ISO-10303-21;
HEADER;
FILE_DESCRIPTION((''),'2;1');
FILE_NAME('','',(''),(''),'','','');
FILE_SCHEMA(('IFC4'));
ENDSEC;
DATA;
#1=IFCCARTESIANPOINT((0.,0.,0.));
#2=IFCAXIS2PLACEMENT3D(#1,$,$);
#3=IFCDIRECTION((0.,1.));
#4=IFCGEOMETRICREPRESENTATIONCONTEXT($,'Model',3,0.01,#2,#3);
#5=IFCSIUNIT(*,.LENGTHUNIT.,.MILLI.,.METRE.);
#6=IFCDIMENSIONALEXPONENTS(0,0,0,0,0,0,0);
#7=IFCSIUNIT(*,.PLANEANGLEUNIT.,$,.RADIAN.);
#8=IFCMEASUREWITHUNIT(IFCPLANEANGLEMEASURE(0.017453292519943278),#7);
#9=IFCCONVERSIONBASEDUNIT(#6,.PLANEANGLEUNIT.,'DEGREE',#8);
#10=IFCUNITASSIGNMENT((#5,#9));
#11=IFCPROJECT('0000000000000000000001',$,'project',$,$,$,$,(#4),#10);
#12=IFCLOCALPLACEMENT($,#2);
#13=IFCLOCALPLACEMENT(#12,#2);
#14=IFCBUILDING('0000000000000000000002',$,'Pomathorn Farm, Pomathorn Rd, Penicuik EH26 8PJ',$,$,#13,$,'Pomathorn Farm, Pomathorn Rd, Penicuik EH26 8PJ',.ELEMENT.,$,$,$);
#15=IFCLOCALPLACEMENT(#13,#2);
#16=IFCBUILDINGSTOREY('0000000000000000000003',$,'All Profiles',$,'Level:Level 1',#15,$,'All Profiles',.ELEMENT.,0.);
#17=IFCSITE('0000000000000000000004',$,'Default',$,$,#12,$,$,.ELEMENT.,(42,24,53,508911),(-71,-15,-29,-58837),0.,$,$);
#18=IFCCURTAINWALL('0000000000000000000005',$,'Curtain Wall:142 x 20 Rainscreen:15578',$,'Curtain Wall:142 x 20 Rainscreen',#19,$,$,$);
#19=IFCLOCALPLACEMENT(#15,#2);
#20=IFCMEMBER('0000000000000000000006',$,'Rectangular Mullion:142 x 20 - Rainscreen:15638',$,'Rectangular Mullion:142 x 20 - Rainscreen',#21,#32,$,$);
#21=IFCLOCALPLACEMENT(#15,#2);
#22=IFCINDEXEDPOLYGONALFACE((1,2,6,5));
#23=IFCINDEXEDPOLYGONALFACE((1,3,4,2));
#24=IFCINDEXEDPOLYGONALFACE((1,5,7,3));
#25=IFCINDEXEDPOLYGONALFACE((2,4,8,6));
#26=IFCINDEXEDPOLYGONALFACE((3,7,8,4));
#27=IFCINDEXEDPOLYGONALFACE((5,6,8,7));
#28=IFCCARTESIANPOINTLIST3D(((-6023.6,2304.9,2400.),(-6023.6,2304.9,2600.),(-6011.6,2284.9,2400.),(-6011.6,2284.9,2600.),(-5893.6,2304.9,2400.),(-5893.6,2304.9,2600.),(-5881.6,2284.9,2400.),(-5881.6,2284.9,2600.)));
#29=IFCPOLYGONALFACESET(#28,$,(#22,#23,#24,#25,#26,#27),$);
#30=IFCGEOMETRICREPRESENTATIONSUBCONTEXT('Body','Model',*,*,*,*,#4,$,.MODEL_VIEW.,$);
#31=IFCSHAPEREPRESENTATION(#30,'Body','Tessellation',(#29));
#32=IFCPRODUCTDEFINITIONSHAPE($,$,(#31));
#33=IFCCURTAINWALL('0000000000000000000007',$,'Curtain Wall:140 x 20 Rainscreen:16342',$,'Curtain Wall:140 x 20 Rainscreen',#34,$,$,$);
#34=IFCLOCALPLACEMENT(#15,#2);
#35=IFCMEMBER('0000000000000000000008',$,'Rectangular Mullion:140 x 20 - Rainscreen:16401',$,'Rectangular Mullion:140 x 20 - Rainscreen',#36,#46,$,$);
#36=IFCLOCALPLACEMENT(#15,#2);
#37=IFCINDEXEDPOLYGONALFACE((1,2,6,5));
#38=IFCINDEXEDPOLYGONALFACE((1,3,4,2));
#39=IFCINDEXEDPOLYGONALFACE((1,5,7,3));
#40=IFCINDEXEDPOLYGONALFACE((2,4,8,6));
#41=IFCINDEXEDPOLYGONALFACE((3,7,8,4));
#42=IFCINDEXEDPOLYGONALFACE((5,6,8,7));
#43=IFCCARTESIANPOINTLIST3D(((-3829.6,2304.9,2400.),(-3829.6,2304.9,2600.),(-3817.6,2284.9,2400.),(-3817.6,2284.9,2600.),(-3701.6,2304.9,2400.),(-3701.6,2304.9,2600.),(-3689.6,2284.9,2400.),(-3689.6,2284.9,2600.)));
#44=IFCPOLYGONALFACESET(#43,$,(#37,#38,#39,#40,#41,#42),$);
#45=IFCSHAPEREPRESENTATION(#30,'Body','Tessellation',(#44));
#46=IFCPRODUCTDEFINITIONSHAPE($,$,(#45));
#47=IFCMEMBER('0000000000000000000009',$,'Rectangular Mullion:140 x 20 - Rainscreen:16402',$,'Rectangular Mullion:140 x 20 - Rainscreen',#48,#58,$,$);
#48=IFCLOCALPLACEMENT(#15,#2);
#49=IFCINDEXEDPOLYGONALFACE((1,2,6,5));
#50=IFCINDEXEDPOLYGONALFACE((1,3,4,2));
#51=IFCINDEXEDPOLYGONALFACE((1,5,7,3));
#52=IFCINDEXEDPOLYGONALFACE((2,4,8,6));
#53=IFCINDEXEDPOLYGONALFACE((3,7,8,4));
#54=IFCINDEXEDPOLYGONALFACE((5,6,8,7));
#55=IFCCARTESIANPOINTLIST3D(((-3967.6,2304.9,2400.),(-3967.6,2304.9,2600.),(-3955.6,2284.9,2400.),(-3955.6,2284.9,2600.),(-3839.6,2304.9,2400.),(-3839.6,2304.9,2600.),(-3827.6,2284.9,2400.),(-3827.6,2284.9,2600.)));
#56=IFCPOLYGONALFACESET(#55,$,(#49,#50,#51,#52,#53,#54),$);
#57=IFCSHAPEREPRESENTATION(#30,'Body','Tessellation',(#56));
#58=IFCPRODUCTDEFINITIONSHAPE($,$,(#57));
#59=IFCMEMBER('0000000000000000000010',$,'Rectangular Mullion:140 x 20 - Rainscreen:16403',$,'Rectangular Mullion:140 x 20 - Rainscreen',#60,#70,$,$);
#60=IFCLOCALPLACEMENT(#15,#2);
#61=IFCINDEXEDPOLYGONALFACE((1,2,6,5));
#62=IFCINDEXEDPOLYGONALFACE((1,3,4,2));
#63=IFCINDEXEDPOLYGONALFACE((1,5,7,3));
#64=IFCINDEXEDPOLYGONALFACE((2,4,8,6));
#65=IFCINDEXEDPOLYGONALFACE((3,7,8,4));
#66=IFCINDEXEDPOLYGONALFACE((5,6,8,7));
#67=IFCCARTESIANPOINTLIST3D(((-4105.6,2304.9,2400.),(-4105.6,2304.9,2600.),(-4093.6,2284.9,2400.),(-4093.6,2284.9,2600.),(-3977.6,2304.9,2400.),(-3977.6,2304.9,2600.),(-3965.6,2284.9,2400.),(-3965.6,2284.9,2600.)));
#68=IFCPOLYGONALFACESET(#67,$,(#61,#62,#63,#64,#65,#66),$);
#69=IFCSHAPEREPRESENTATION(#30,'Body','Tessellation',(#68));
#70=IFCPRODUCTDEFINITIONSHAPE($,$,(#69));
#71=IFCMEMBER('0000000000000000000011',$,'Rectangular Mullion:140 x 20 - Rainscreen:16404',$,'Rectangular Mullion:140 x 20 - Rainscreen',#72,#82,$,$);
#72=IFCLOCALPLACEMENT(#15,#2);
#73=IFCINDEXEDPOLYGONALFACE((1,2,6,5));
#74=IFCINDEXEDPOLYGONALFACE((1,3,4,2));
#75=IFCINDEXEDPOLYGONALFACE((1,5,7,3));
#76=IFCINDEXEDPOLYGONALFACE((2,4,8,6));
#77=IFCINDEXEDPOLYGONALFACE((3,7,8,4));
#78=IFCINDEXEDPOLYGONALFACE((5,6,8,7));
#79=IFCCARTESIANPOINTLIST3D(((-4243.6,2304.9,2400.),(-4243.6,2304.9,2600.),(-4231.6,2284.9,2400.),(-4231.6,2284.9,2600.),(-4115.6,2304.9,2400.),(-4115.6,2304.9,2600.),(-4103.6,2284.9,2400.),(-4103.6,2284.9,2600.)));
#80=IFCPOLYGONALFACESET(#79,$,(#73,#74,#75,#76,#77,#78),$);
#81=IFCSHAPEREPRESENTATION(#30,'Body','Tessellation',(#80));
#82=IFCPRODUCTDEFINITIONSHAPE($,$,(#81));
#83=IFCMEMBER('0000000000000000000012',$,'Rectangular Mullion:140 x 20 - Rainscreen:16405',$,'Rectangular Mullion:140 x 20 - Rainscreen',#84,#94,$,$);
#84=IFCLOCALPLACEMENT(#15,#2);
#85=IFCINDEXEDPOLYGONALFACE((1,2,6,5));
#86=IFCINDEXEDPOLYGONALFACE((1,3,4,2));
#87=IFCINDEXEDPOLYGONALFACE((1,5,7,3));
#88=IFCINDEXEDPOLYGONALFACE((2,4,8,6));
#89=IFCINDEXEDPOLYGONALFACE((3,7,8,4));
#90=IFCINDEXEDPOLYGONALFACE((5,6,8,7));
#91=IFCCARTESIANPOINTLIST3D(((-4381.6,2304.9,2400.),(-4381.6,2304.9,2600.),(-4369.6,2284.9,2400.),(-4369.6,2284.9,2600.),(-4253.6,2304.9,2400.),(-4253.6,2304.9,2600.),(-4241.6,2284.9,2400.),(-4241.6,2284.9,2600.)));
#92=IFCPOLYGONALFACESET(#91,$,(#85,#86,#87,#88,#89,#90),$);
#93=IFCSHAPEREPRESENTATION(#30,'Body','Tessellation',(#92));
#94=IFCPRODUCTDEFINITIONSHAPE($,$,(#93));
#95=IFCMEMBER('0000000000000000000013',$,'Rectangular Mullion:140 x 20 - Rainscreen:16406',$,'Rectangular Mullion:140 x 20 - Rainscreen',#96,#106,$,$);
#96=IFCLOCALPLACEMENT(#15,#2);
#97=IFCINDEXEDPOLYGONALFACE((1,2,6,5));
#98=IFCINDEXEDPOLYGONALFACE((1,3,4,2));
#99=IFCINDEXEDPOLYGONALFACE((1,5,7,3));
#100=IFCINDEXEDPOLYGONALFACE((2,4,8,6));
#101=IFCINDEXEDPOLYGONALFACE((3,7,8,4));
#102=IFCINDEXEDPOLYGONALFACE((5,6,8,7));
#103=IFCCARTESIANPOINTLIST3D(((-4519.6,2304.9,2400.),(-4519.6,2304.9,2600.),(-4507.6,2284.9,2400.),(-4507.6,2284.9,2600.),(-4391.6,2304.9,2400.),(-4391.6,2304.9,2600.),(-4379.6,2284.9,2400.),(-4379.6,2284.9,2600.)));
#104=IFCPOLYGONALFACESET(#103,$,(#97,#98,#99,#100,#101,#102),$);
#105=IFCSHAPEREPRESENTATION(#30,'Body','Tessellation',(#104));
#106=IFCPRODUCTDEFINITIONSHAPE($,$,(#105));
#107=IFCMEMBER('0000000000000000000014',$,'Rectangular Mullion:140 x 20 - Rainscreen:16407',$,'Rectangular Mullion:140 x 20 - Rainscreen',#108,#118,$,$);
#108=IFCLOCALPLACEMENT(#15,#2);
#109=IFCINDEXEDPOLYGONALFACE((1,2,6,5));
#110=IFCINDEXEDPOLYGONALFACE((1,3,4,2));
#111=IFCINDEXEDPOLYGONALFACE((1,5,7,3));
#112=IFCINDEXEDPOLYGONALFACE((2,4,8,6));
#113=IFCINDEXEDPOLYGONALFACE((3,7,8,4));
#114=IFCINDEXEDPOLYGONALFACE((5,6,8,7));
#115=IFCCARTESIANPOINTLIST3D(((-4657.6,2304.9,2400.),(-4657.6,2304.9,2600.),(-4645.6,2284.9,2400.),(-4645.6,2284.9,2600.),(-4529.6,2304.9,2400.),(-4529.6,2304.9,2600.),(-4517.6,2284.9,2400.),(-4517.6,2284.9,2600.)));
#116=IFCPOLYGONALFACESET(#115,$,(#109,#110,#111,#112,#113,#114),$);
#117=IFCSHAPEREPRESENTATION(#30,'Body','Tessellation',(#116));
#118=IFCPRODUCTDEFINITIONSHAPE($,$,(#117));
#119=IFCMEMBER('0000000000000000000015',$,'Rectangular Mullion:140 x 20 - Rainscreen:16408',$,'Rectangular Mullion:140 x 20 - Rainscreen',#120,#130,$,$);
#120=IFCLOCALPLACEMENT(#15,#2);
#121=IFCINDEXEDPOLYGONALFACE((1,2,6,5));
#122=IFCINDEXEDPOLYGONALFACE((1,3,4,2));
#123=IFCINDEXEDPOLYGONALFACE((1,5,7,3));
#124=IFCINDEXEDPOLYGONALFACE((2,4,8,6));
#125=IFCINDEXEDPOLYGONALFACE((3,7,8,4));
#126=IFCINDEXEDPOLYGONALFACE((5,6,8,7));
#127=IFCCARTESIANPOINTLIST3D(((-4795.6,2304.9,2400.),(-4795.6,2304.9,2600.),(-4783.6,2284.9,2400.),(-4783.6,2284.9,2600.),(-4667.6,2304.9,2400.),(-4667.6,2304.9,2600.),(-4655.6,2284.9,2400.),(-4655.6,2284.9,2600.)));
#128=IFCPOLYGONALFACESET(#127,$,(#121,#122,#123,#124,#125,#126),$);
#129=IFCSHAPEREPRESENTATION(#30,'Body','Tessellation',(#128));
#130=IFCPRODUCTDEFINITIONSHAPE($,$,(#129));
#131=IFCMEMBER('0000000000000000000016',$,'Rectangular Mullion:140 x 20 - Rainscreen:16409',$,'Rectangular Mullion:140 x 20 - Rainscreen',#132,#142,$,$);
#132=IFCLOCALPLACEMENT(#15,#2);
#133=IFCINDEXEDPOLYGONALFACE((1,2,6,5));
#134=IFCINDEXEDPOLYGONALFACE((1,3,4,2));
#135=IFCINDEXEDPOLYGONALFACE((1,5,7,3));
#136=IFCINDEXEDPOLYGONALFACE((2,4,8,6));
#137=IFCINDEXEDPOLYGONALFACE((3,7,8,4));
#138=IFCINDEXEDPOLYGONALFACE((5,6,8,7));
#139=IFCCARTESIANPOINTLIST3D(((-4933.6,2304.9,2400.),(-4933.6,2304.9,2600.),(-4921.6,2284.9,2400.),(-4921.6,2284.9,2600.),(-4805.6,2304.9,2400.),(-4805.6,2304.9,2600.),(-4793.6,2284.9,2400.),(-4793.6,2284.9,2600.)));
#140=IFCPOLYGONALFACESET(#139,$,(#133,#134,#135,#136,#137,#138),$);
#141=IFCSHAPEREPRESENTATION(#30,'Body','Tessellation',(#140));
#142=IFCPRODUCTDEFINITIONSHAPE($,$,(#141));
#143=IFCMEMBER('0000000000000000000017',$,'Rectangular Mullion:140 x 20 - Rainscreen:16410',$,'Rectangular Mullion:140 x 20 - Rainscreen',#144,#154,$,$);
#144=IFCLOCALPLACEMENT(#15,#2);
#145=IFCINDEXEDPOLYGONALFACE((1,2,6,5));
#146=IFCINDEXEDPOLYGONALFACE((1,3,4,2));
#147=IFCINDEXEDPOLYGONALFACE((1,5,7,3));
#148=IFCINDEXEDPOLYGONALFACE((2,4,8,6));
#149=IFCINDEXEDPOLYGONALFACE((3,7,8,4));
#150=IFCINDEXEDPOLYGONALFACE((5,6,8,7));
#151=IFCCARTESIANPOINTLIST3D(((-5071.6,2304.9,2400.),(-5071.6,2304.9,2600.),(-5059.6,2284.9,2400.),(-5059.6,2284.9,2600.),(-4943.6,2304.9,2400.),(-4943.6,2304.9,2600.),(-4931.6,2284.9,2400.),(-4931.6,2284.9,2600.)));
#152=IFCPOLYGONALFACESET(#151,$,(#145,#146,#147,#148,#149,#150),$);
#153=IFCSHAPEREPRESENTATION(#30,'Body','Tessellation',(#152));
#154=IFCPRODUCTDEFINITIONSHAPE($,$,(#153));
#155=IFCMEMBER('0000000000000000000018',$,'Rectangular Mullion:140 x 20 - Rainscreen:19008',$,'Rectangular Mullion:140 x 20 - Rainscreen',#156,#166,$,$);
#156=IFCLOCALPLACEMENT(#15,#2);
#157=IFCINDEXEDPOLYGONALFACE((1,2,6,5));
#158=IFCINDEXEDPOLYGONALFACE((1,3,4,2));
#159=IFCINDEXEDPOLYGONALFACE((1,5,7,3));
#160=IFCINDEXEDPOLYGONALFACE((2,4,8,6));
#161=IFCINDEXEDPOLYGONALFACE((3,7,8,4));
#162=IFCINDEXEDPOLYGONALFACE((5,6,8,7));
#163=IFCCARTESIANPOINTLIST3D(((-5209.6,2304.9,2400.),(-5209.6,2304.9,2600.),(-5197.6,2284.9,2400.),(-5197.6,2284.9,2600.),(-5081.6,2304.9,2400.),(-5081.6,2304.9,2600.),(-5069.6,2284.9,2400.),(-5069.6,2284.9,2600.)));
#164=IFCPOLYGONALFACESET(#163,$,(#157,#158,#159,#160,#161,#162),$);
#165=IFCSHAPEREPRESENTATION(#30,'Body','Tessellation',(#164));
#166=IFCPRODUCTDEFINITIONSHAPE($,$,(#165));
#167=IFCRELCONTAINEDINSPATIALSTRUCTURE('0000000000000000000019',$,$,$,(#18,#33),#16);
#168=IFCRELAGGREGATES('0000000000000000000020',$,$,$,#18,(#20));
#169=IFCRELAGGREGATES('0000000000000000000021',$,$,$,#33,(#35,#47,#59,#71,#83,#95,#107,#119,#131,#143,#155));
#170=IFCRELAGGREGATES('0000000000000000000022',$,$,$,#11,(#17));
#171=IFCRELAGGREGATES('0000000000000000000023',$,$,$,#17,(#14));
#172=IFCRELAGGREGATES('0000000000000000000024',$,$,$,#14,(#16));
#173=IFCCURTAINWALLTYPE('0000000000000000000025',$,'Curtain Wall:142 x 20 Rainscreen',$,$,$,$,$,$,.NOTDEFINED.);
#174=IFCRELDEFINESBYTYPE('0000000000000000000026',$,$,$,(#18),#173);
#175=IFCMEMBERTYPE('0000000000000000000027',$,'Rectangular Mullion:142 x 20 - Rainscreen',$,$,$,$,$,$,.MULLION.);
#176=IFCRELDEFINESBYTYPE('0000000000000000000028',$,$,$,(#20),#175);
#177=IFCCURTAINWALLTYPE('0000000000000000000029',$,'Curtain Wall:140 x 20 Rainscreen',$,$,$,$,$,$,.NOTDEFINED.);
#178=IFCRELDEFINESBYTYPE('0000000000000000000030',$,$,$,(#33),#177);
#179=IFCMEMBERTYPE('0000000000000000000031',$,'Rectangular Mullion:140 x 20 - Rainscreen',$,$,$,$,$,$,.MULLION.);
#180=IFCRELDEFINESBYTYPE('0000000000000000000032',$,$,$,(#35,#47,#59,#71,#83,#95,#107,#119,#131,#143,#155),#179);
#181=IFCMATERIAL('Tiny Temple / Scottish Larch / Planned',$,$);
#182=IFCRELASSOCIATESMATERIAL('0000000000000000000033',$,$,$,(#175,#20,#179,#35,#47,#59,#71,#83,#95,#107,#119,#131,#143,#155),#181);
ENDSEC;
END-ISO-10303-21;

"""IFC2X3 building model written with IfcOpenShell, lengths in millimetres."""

from ifc_helpers import new_model, entity, si_unit, converted_unit, direction, frame, origin, place, context, subcontext, project, spatial, polyline, outline, extrude, source, transform, mapped, material, type_object, type_shapes, element, aggregate, save


model = new_model("IFC2X3")

# Units and contexts
model_context = context("Model", 3, precision=0.01, world=origin(), true_north=direction((0.0, 1.0)))
body_context = subcontext(model_context, "Body", "Model", "MODEL_VIEW")
ifc_project = project(units=[si_unit("LENGTHUNIT", "METRE", prefix="MILLI"), converted_unit("PLANEANGLEUNIT", "DEGREE", entity("IfcPlaneAngleMeasure", 0.017453292519943278), si_unit("PLANEANGLEUNIT", "RADIAN"), dimensions=[0, 0, 0, 0, 0, 0, 0])], contexts=[model_context])

# Site, building, storey
site_placement = place(None, origin())
site = spatial("IfcSite", under=ifc_project, at=site_placement, Name="Default", CompositionType="ELEMENT", RefLatitude=(42, 24, 53, 508911), RefLongitude=(-71, -15, -29, -58837), RefElevation=0.0)
building_placement = place(site_placement, origin())
building = spatial("IfcBuilding", under=site, at=building_placement, Name="Pomathorn Farm, Pomathorn Rd, Penicuik EH26 8PJ", LongName="Pomathorn Farm, Pomathorn Rd, Penicuik EH26 8PJ", CompositionType="ELEMENT")
storey_placement = place(building_placement, origin())
storey = spatial("IfcBuildingStorey", under=building, at=storey_placement, Name="All Profiles", ObjectType="Level:Level 1", LongName="All Profiles", CompositionType="ELEMENT", Elevation=0.0)

# Curtain walls, members
ifc_material = material(Name="Tiny Temple / Scottish Larch / Planned")
curtain_wall_type_1 = type_object("IfcCurtainWallType", Name="Curtain Wall:142 x 20 Rainscreen", PredefinedType="NOTDEFINED")
curtain_wall_1_placement = place(storey_placement, origin())
curtain_wall_1 = element("IfcCurtainWall", 1, at=curtain_wall_1_placement, inside=storey, type_object=curtain_wall_type_1, Name="Curtain Wall:142 x 20 Rainscreen:15578", ObjectType="Curtain Wall:142 x 20 Rainscreen")
member_type_1 = type_object("IfcMemberType", Name="Rectangular Mullion:142 x 20 - Rainscreen", PredefinedType="MULLION", material=ifc_material)
shared_shape_1 = source(origin(), body_context, "Body", "SweptSolid", [
    extrude(outline(polyline([(21.8, -55.7), (45.1, -55.7), (-21.8, 55.7), (-45.1, 55.7), (21.8, -55.7)])), frame((-71.0, -10.0, -200.0), z_axis=(0.0, 0.0, 1.0), x_axis=(0.514496, 0.857493, 0.0)), (0.0, 0.0, 1.0), 200.0),
])
type_shapes(member_type_1, [shared_shape_1])
member_1_placement = place(curtain_wall_1_placement, frame((-5881.6, 2284.9, 2400.0), z_axis=(0.0, 0.0, -1.0), x_axis=(1.0, 0.0, 0.0)))
member_1 = element("IfcMember", 2, at=member_1_placement, type_object=member_type_1, material=ifc_material, Name="Rectangular Mullion:142 x 20 - Rainscreen:15638", ObjectType="Rectangular Mullion:142 x 20 - Rainscreen", context=body_context, shape_type="MappedRepresentation", body=[
    mapped(shared_shape_1, transform((0.0, 0.0, 0.0), scale=1.0)),
])
aggregate(curtain_wall_1, [member_1])
curtain_wall_type_2 = type_object("IfcCurtainWallType", Name="Curtain Wall:140 x 20 Rainscreen", PredefinedType="NOTDEFINED")
curtain_wall_2_placement = place(storey_placement, origin())
curtain_wall_2 = element("IfcCurtainWall", 3, at=curtain_wall_2_placement, inside=storey, type_object=curtain_wall_type_2, Name="Curtain Wall:140 x 20 Rainscreen:16342", ObjectType="Curtain Wall:140 x 20 Rainscreen")
member_type_2 = type_object("IfcMemberType", Name="Rectangular Mullion:140 x 20 - Rainscreen", PredefinedType="MULLION", material=ifc_material)
shared_shape_2 = source(origin(), body_context, "Body", "SweptSolid", [
    extrude(outline(polyline([(21.3, -54.9), (44.6, -54.9), (-21.3, 54.9), (-44.6, 54.9), (21.3, -54.9)])), frame((-70.0, -10.0, -200.0), z_axis=(0.0, 0.0, 1.0), x_axis=(0.514496, 0.857493, 0.0)), (0.0, 0.0, 1.0), 200.0),
])
type_shapes(member_type_2, [shared_shape_2])
member_2_placement = place(curtain_wall_2_placement, frame((-3689.6, 2284.9, 2400.0), z_axis=(0.0, 0.0, -1.0), x_axis=(1.0, 0.0, 0.0)))
member_2 = element("IfcMember", 4, at=member_2_placement, type_object=member_type_2, material=ifc_material, Name="Rectangular Mullion:140 x 20 - Rainscreen:16401", ObjectType="Rectangular Mullion:140 x 20 - Rainscreen", context=body_context, shape_type="MappedRepresentation", body=[
    mapped(shared_shape_2, transform((0.0, 0.0, 0.0), scale=1.0)),
])
member_3_placement = place(curtain_wall_2_placement, frame((-3827.6, 2284.9, 2400.0), z_axis=(0.0, 0.0, -1.0), x_axis=(1.0, 0.0, 0.0)))
member_3 = element("IfcMember", 5, at=member_3_placement, type_object=member_type_2, material=ifc_material, Name="Rectangular Mullion:140 x 20 - Rainscreen:16402", ObjectType="Rectangular Mullion:140 x 20 - Rainscreen", context=body_context, shape_type="MappedRepresentation", body=[
    mapped(shared_shape_2, transform((0.0, 0.0, 0.0), scale=1.0)),
])
member_4_placement = place(curtain_wall_2_placement, frame((-3965.6, 2284.9, 2400.0), z_axis=(0.0, 0.0, -1.0), x_axis=(1.0, 0.0, 0.0)))
member_4 = element("IfcMember", 6, at=member_4_placement, type_object=member_type_2, material=ifc_material, Name="Rectangular Mullion:140 x 20 - Rainscreen:16403", ObjectType="Rectangular Mullion:140 x 20 - Rainscreen", context=body_context, shape_type="MappedRepresentation", body=[
    mapped(shared_shape_2, transform((0.0, 0.0, 0.0), scale=1.0)),
])
member_5_placement = place(curtain_wall_2_placement, frame((-4103.6, 2284.9, 2400.0), z_axis=(0.0, 0.0, -1.0), x_axis=(1.0, 0.0, 0.0)))
member_5 = element("IfcMember", 7, at=member_5_placement, type_object=member_type_2, material=ifc_material, Name="Rectangular Mullion:140 x 20 - Rainscreen:16404", ObjectType="Rectangular Mullion:140 x 20 - Rainscreen", context=body_context, shape_type="MappedRepresentation", body=[
    mapped(shared_shape_2, transform((0.0, 0.0, 0.0), scale=1.0)),
])
member_6_placement = place(curtain_wall_2_placement, frame((-4241.6, 2284.9, 2400.0), z_axis=(0.0, 0.0, -1.0), x_axis=(1.0, 0.0, 0.0)))
member_6 = element("IfcMember", 8, at=member_6_placement, type_object=member_type_2, material=ifc_material, Name="Rectangular Mullion:140 x 20 - Rainscreen:16405", ObjectType="Rectangular Mullion:140 x 20 - Rainscreen", context=body_context, shape_type="MappedRepresentation", body=[
    mapped(shared_shape_2, transform((0.0, 0.0, 0.0), scale=1.0)),
])
member_7_placement = place(curtain_wall_2_placement, frame((-4379.6, 2284.9, 2400.0), z_axis=(0.0, 0.0, -1.0), x_axis=(1.0, 0.0, 0.0)))
member_7 = element("IfcMember", 9, at=member_7_placement, type_object=member_type_2, material=ifc_material, Name="Rectangular Mullion:140 x 20 - Rainscreen:16406", ObjectType="Rectangular Mullion:140 x 20 - Rainscreen", context=body_context, shape_type="MappedRepresentation", body=[
    mapped(shared_shape_2, transform((0.0, 0.0, 0.0), scale=1.0)),
])
member_8_placement = place(curtain_wall_2_placement, frame((-4517.6, 2284.9, 2400.0), z_axis=(0.0, 0.0, -1.0), x_axis=(1.0, 0.0, 0.0)))
member_8 = element("IfcMember", 10, at=member_8_placement, type_object=member_type_2, material=ifc_material, Name="Rectangular Mullion:140 x 20 - Rainscreen:16407", ObjectType="Rectangular Mullion:140 x 20 - Rainscreen", context=body_context, shape_type="MappedRepresentation", body=[
    mapped(shared_shape_2, transform((0.0, 0.0, 0.0), scale=1.0)),
])
member_9_placement = place(curtain_wall_2_placement, frame((-4655.6, 2284.9, 2400.0), z_axis=(0.0, 0.0, -1.0), x_axis=(1.0, 0.0, 0.0)))
member_9 = element("IfcMember", 11, at=member_9_placement, type_object=member_type_2, material=ifc_material, Name="Rectangular Mullion:140 x 20 - Rainscreen:16408", ObjectType="Rectangular Mullion:140 x 20 - Rainscreen", context=body_context, shape_type="MappedRepresentation", body=[
    mapped(shared_shape_2, transform((0.0, 0.0, 0.0), scale=1.0)),
])
member_10_placement = place(curtain_wall_2_placement, frame((-4793.6, 2284.9, 2400.0), z_axis=(0.0, 0.0, -1.0), x_axis=(1.0, 0.0, 0.0)))
member_10 = element("IfcMember", 12, at=member_10_placement, type_object=member_type_2, material=ifc_material, Name="Rectangular Mullion:140 x 20 - Rainscreen:16409", ObjectType="Rectangular Mullion:140 x 20 - Rainscreen", context=body_context, shape_type="MappedRepresentation", body=[
    mapped(shared_shape_2, transform((0.0, 0.0, 0.0), scale=1.0)),
])
member_11_placement = place(curtain_wall_2_placement, frame((-4931.6, 2284.9, 2400.0), z_axis=(0.0, 0.0, -1.0), x_axis=(1.0, 0.0, 0.0)))
member_11 = element("IfcMember", 13, at=member_11_placement, type_object=member_type_2, material=ifc_material, Name="Rectangular Mullion:140 x 20 - Rainscreen:16410", ObjectType="Rectangular Mullion:140 x 20 - Rainscreen", context=body_context, shape_type="MappedRepresentation", body=[
    mapped(shared_shape_2, transform((0.0, 0.0, 0.0), scale=1.0)),
])
member_12_placement = place(curtain_wall_2_placement, frame((-5069.6, 2284.9, 2400.0), z_axis=(0.0, 0.0, -1.0), x_axis=(1.0, 0.0, 0.0)))
member_12 = element("IfcMember", 14, at=member_12_placement, type_object=member_type_2, material=ifc_material, Name="Rectangular Mullion:140 x 20 - Rainscreen:19008", ObjectType="Rectangular Mullion:140 x 20 - Rainscreen", context=body_context, shape_type="MappedRepresentation", body=[
    mapped(shared_shape_2, transform((0.0, 0.0, 0.0), scale=1.0)),
])
aggregate(curtain_wall_2, [member_2, member_3, member_4, member_5, member_6, member_7, member_8, member_9, member_10, member_11, member_12])

save(model, "model.ifc")
